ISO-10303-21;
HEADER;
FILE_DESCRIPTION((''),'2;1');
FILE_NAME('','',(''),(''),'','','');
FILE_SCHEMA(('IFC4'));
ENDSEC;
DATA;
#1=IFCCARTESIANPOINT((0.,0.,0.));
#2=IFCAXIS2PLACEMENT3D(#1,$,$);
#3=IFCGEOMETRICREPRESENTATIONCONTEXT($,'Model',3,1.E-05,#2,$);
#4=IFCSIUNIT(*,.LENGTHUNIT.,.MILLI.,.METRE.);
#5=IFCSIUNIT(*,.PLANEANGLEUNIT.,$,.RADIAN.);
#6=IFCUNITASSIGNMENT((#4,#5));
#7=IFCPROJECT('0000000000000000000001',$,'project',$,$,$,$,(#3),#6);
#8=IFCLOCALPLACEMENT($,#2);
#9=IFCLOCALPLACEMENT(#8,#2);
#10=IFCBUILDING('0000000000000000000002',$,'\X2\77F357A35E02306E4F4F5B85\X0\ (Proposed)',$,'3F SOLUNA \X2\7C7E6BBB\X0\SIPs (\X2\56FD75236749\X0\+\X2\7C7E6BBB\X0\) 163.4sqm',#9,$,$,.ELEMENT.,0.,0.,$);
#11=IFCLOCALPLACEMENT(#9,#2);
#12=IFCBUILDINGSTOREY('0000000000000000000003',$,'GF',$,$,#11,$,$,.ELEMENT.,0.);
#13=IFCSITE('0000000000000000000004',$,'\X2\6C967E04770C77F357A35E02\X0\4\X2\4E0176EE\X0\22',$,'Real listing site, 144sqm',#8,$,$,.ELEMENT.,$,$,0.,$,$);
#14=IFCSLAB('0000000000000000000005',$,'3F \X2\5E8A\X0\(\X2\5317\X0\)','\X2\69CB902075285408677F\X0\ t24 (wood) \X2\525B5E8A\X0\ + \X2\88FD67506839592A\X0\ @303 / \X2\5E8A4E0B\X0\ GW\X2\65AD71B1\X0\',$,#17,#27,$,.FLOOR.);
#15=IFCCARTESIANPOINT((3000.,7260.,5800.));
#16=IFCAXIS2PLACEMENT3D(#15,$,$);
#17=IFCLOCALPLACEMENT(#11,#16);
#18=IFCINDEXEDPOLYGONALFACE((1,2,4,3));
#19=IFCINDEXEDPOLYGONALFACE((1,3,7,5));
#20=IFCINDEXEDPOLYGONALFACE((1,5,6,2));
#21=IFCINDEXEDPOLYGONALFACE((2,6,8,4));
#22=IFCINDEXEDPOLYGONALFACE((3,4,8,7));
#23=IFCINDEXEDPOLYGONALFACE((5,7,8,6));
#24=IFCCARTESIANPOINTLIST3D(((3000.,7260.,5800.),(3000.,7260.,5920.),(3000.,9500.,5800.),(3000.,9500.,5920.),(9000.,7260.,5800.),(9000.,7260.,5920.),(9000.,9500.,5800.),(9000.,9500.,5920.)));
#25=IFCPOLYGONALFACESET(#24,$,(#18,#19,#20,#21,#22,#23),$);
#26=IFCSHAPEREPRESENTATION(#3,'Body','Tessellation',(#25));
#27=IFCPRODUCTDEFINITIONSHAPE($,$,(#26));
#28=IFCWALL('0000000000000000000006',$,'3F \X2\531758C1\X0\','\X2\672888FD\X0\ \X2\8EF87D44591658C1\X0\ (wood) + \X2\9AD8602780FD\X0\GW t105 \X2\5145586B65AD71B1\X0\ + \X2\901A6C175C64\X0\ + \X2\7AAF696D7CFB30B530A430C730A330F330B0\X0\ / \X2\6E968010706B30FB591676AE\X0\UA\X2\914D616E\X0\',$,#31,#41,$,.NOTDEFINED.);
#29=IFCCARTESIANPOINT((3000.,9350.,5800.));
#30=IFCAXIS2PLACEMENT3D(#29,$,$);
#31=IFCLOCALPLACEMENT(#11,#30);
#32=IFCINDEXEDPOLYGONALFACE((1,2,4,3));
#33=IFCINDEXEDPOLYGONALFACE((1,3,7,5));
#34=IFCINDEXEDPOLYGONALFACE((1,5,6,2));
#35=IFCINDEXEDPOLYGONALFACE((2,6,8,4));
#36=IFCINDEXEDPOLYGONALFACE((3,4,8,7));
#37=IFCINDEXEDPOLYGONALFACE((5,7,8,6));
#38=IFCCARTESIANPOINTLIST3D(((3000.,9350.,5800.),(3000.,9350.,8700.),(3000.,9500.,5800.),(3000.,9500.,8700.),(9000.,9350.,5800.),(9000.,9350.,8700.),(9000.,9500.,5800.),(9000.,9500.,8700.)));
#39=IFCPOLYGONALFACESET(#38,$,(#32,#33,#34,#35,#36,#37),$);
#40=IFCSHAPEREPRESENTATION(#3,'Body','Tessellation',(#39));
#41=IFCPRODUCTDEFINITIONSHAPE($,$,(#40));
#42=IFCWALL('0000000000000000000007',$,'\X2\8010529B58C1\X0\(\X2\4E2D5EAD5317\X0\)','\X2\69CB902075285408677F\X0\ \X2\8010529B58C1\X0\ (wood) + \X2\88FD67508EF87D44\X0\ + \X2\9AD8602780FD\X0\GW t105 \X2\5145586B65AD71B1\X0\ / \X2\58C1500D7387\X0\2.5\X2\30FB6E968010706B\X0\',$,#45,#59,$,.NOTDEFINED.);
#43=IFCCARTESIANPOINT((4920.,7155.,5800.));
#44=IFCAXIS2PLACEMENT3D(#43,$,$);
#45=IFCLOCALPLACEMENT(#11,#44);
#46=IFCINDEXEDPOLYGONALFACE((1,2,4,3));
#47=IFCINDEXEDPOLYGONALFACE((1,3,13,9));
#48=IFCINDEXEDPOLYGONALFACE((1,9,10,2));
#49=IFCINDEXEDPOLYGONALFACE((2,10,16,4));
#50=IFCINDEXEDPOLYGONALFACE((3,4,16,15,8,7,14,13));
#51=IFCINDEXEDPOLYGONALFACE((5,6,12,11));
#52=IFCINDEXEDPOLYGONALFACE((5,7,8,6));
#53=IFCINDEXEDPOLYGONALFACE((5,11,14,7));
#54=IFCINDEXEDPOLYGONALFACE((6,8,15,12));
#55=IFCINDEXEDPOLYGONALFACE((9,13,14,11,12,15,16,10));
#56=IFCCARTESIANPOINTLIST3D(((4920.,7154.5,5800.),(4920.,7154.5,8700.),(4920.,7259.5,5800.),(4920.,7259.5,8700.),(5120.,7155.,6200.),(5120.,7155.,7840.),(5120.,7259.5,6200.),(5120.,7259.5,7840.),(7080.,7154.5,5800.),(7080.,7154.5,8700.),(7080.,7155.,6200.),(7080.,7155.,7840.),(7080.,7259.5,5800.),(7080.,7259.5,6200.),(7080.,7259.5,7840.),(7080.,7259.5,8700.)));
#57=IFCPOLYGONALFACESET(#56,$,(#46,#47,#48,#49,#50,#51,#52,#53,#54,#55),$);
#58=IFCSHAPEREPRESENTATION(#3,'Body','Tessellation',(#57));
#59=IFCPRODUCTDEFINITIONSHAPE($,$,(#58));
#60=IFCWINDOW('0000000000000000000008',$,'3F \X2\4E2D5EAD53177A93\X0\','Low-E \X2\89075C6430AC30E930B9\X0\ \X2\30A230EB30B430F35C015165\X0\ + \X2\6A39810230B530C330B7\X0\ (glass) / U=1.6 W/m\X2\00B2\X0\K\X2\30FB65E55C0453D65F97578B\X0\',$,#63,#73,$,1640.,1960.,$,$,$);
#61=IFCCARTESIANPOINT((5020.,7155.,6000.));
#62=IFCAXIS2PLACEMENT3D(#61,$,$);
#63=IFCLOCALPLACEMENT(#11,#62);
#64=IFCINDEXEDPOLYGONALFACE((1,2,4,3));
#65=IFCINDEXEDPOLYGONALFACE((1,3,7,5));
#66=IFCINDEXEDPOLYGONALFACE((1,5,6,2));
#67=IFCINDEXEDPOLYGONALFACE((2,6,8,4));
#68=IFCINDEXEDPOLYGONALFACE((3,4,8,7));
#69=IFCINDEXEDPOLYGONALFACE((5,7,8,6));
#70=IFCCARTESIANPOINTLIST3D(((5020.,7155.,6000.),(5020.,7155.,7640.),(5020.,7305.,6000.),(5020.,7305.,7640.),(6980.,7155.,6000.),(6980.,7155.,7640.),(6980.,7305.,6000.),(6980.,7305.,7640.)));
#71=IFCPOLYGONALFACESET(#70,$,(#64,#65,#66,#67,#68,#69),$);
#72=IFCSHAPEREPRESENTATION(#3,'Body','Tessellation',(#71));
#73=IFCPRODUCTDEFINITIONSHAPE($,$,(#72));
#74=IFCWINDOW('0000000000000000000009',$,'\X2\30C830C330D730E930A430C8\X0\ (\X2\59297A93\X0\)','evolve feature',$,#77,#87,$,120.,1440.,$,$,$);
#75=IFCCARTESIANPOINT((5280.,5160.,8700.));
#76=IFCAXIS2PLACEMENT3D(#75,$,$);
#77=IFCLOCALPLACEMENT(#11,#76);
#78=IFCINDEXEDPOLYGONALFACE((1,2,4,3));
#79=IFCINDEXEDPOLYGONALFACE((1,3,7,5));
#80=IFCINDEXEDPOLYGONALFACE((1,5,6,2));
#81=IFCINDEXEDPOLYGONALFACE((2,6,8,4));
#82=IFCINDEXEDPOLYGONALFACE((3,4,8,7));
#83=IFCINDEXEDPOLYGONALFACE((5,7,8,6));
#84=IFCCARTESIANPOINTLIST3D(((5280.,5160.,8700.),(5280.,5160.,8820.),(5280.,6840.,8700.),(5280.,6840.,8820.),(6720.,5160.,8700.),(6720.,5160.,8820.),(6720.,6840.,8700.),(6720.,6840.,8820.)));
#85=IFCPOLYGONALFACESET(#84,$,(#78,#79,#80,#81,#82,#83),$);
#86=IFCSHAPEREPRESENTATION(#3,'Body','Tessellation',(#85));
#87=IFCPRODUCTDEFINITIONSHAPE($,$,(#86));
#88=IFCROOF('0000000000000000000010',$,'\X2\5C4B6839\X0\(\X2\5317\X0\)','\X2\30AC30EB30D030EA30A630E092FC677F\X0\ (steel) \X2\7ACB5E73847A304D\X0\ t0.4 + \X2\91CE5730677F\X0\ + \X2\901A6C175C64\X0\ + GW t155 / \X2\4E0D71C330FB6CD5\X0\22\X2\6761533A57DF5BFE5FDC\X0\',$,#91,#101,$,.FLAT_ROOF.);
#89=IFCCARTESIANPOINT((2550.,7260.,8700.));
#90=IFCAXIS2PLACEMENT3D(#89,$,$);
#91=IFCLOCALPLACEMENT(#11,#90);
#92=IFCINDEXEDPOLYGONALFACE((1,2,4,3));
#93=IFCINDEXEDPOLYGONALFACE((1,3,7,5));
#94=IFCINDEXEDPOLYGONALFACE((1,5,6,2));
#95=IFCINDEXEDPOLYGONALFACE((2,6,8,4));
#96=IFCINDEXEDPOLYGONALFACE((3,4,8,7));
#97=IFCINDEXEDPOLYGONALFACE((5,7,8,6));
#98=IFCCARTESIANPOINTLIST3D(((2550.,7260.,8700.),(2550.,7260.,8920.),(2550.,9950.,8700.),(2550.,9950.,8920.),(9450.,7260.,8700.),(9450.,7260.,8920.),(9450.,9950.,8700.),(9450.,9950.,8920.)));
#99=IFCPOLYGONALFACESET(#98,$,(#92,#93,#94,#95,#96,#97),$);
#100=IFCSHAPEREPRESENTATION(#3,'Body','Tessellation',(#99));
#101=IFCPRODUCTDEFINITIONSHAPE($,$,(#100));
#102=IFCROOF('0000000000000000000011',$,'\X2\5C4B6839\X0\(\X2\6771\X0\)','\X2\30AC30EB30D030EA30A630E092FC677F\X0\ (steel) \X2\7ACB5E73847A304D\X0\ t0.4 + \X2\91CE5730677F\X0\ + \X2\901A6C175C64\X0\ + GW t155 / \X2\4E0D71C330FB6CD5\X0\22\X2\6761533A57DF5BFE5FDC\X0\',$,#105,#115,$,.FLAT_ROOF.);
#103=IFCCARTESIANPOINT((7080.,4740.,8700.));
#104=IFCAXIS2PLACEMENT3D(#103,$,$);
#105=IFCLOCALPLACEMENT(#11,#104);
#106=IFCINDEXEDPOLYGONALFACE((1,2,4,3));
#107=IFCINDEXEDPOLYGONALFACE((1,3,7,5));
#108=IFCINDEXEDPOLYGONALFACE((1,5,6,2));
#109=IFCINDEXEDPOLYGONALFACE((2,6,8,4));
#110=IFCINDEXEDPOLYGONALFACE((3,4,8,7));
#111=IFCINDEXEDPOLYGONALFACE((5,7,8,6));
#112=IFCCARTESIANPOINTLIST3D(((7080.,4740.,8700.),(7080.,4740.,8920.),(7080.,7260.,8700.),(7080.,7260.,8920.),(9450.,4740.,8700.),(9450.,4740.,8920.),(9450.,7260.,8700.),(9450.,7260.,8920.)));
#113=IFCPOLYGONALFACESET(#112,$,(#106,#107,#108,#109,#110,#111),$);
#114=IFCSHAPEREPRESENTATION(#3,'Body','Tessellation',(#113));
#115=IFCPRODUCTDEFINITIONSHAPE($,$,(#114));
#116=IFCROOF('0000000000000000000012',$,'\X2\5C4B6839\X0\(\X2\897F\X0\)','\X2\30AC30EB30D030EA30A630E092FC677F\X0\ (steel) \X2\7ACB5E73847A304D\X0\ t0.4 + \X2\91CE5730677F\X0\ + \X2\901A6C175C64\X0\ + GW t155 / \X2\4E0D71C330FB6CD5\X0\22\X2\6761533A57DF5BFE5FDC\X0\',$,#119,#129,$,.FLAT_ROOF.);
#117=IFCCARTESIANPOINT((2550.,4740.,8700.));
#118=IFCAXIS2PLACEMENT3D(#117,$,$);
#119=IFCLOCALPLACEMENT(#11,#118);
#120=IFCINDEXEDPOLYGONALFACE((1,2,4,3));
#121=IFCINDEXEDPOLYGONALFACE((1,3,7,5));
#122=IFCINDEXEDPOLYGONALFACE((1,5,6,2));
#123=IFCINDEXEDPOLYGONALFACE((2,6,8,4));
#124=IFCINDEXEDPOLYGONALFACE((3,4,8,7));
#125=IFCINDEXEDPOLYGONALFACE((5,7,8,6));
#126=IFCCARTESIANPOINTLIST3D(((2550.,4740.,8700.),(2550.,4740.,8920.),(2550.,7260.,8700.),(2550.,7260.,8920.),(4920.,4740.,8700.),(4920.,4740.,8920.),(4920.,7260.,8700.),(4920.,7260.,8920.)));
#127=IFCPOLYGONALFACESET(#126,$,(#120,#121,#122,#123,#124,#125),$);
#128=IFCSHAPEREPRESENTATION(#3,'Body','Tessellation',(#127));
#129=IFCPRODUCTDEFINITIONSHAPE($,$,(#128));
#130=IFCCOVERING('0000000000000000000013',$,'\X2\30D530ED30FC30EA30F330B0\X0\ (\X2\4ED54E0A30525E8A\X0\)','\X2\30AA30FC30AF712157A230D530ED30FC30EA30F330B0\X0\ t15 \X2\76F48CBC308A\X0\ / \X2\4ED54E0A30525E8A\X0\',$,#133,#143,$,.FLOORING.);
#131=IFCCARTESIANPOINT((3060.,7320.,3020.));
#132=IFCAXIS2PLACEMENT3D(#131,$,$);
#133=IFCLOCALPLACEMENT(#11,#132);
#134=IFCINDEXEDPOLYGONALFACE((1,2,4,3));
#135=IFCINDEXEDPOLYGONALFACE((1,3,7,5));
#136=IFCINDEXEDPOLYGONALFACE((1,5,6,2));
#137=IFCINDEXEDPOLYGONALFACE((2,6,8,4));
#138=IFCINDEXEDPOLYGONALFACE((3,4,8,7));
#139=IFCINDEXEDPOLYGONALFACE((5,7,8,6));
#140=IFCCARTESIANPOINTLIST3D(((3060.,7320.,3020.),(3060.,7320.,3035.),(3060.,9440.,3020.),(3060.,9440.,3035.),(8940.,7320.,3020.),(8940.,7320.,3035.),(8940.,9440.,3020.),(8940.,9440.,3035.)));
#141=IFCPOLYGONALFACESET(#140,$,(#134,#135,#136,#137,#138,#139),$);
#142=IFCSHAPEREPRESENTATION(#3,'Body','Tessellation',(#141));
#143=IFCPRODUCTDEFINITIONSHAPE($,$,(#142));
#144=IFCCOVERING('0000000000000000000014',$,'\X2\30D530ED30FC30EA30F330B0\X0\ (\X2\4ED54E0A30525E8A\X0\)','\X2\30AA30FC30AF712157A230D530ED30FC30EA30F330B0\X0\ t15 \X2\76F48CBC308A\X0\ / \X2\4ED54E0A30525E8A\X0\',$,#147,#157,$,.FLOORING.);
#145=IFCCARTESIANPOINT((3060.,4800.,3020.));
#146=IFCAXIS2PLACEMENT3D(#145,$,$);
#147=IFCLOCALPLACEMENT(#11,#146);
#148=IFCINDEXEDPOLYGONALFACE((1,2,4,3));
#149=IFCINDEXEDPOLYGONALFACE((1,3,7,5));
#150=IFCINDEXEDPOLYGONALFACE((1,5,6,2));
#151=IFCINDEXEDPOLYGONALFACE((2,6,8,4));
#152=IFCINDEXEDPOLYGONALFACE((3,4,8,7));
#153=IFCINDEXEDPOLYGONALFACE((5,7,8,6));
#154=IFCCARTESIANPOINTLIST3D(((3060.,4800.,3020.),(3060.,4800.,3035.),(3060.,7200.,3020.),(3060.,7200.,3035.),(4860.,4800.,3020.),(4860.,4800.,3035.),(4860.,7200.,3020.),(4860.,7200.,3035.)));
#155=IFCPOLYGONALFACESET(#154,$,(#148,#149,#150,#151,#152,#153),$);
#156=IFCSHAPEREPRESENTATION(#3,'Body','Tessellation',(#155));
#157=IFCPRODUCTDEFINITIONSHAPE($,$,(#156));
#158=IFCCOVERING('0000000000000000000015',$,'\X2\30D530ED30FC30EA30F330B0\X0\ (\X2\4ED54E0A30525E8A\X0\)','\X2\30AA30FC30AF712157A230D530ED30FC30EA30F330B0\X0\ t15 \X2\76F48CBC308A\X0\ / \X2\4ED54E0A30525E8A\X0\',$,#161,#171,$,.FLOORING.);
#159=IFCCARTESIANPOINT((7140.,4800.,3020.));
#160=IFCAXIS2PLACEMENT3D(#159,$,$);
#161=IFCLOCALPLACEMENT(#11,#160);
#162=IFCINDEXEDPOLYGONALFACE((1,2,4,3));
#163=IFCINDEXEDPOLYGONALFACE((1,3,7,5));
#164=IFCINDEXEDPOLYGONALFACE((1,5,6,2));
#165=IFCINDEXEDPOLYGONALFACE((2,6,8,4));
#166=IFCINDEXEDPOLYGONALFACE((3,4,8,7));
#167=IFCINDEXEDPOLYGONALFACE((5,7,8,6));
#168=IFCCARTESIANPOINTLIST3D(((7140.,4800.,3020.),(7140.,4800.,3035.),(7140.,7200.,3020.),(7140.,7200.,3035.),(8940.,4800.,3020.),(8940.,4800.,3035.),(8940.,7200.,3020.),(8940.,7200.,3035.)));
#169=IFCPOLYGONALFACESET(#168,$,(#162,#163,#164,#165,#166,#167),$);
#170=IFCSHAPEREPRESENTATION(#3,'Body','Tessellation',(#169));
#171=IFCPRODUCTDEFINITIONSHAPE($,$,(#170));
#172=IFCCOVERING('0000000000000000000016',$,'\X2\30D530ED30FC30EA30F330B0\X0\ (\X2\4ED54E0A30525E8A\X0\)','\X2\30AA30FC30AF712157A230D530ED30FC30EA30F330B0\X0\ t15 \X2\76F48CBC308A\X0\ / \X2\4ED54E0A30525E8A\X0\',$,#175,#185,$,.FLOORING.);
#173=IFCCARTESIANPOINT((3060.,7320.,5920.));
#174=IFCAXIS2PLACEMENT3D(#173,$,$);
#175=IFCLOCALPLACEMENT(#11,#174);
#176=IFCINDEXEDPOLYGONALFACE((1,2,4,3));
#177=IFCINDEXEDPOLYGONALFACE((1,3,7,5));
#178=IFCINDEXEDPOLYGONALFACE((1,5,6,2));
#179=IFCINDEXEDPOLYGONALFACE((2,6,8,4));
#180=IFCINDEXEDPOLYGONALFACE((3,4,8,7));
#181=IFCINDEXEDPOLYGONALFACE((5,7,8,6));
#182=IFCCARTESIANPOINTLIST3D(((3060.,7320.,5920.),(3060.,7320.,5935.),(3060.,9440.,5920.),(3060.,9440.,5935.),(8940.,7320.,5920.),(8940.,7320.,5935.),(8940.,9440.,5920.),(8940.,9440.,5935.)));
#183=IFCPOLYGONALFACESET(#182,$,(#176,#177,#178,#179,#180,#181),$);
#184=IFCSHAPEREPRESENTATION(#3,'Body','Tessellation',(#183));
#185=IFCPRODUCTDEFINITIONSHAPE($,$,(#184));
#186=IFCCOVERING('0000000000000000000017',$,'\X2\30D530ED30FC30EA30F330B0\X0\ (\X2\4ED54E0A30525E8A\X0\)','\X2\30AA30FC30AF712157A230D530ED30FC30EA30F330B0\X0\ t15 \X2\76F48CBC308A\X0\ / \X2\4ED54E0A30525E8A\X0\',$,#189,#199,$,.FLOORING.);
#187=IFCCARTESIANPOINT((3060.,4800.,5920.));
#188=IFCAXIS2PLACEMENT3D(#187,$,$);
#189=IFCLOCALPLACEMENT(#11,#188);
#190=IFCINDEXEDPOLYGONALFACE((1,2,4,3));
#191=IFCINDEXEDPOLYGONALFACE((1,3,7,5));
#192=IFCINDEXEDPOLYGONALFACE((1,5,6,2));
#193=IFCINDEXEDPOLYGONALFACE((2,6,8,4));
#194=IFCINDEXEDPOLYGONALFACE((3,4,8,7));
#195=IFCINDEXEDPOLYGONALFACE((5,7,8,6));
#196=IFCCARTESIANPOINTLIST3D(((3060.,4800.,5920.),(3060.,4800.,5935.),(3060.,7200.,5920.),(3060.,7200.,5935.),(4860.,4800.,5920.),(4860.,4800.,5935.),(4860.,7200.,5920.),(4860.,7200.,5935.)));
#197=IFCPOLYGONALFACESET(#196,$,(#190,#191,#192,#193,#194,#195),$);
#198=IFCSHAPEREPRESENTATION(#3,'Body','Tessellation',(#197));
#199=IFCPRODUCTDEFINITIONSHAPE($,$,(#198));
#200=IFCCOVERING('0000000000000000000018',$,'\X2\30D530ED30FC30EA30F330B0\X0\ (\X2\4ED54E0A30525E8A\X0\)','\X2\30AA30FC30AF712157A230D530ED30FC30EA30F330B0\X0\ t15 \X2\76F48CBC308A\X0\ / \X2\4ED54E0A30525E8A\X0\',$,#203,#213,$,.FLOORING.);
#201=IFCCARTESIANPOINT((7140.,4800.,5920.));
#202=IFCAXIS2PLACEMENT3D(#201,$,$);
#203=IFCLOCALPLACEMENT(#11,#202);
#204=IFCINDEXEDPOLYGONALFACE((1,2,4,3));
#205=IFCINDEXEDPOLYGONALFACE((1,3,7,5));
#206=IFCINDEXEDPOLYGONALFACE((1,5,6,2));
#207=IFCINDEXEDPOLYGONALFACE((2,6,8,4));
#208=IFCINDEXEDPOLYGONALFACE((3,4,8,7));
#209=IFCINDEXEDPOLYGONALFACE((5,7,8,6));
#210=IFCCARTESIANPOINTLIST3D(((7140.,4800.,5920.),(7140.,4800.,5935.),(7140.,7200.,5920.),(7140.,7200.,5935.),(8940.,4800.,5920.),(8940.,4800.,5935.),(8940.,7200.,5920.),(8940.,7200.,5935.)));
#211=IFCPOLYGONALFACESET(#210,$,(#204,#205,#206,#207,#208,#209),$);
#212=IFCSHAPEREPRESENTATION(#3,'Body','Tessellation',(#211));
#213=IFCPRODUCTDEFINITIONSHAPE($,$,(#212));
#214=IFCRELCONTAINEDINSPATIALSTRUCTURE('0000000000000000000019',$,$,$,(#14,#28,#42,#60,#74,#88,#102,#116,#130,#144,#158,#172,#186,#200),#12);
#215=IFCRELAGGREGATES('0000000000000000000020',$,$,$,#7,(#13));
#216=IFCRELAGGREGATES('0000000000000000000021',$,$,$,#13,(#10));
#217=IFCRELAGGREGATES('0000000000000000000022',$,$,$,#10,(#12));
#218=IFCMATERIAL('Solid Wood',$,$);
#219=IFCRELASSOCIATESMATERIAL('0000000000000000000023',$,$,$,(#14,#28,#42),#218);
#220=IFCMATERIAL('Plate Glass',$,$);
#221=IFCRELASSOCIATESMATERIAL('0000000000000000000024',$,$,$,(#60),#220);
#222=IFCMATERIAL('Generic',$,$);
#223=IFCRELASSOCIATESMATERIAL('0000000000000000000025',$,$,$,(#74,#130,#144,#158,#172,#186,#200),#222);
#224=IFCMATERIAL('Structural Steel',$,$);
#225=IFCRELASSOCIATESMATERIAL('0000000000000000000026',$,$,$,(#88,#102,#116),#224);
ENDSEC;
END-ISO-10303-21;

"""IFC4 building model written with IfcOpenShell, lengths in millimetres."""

from ifc_helpers import new_model, si_unit, frame, frame_2d, origin, place, context, project, spatial, rectangle, extrude, material, element, fill, save


model = new_model("IFC4")

# Units and contexts
model_context = context("Model", 3, precision=1e-05, world=origin())
ifc_project = project(units=[si_unit("LENGTHUNIT", "METRE", prefix="MILLI"), si_unit("PLANEANGLEUNIT", "RADIAN")], contexts=[model_context])

# Site, building, storey
site_placement = place(None, origin())
site = spatial("IfcSite", under=ifc_project, at=site_placement, Name="沖縄県石垣市4丁目22", ObjectType="Real listing site, 144sqm", CompositionType="ELEMENT", RefElevation=0.0)
building_placement = place(site_placement, origin())
building = spatial("IfcBuilding", under=site, at=building_placement, Name="石垣市の住宅 (Proposed)", ObjectType="3F SOLUNA 籾殻SIPs (国産杉+籾殻) 163.4sqm", CompositionType="ELEMENT", ElevationOfRefHeight=0.0, ElevationOfTerrain=0.0)
storey_placement = place(building_placement, origin())
storey = spatial("IfcBuildingStorey", under=building, at=storey_placement, Name="GF", CompositionType="ELEMENT", Elevation=0.0)

# Slab
ifc_material_1 = material(Name="Solid Wood")
slab_placement = place(storey_placement, frame((3000.0, 7260.0, 5800.0)))
element("IfcSlab", 1, at=slab_placement, inside=storey, material=ifc_material_1, Name="3F 床(北)", Description="構造用合板 t24 (wood) 剛床 + 製材根太 @303 / 床下 GW断熱", PredefinedType="FLOOR", context=model_context, shape_type="SweptSolid", body=[
    extrude(rectangle(XDim=6000.0, YDim=2240.0, at=frame_2d((3000.0, 1120.0))), frame((3000.0, 7260.0, 5800.0)), (0.0, 0.0, 1.0), 120.0),
])

# Wall
wall_1_placement = place(storey_placement, frame((3000.0, 9350.0, 5800.0)))
element("IfcWall", 2, at=wall_1_placement, inside=storey, material=ifc_material_1, Name="3F 北壁", Description="木製 軸組外壁 (wood) + 高性能GW t105 充填断熱 + 通気層 + 窯業系サイディング / 準耐火・外皮UA配慮", PredefinedType="NOTDEFINED", context=model_context, shape_type="SweptSolid", body=[
    extrude(rectangle(XDim=6000.0, YDim=150.0, at=frame_2d((3000.0, 75.0))), frame((3000.0, 9350.0, 5800.0)), (0.0, 0.0, 1.0), 2900.0),
])

# Wall, opening, window
wall_2_placement = place(storey_placement, frame((4920.0, 7155.0, 5800.0)))
wall_2 = element("IfcWall", 3, at=wall_2_placement, inside=storey, material=ifc_material_1, Name="耐力壁(中庭北)", Description="構造用合板 耐力壁 (wood) + 製材軸組 + 高性能GW t105 充填断熱 / 壁倍率2.5・準耐火", PredefinedType="NOTDEFINED", context=model_context, shape_type="SweptSolid", body=[
    extrude(rectangle(XDim=2160.0, YDim=105.0, at=frame_2d((1080.0, 52.0))), frame((4920.0, 7155.0, 5800.0)), (0.0, 0.0, 1.0), 2900.0),
])
opening_placement = place(storey_placement, frame((5020.0, 7155.0, 6000.0)))
opening = element("IfcOpeningElement", 4, at=opening_placement, cuts=wall_2, PredefinedType="NOTDEFINED", context=model_context, shape_type="SweptSolid", body=[
    extrude(rectangle(XDim=1960.0, YDim=150.0, at=frame_2d((980.0, 75.0))), frame((5020.0, 7155.0, 6000.0)), (0.0, 0.0, 1.0), 1640.0),
])
ifc_material_2 = material(Name="Plate Glass")
window_1_placement = place(storey_placement, frame((5020.0, 7155.0, 6000.0)))
window_1 = element("IfcWindow", 5, at=window_1_placement, inside=storey, material=ifc_material_2, Name="3F 中庭北窓", Description="Low-E 複層ガラス アルゴン封入 + 樹脂サッシ (glass) / U=1.6 W/m²K・日射取得型", OverallHeight=1640.0, OverallWidth=1960.0, context=model_context, shape_type="SweptSolid", body=[
    extrude(rectangle(XDim=1960.0, YDim=150.0, at=frame_2d((980.0, 75.0))), frame((5020.0, 7155.0, 6000.0)), (0.0, 0.0, 1.0), 1640.0),
])
fill(opening, window_1)

# Window
ifc_material_3 = material(Name="Generic")
window_2_placement = place(storey_placement, frame((5280.0, 5160.0, 8700.0)))
element("IfcWindow", 6, at=window_2_placement, inside=storey, material=ifc_material_3, Name="トップライト (天窓)", Description="evolve feature", OverallHeight=120.0, OverallWidth=1440.0, context=model_context, shape_type="SweptSolid", body=[
    extrude(rectangle(XDim=1440.0, YDim=1680.0, at=frame_2d((720.0, 840.0))), frame((5280.0, 5160.0, 8700.0)), (0.0, 0.0, 1.0), 120.0),
])

# Roofs
ifc_material_4 = material(Name="Structural Steel")
roof_1_placement = place(storey_placement, frame((2550.0, 7260.0, 8700.0)))
element("IfcRoof", 7, at=roof_1_placement, inside=storey, material=ifc_material_4, Name="屋根(北)", Description="ガルバリウム鋼板 (steel) 立平葺き t0.4 + 野地板 + 通気層 + GW t155 / 不燃・法22条区域対応", PredefinedType="FLAT_ROOF", context=model_context, shape_type="SweptSolid", body=[
    extrude(rectangle(XDim=6900.0, YDim=2690.0, at=frame_2d((3450.0, 1345.0))), frame((2550.0, 7260.0, 8700.0)), (0.0, 0.0, 1.0), 220.0),
])
roof_2_placement = place(storey_placement, frame((7080.0, 4740.0, 8700.0)))
element("IfcRoof", 8, at=roof_2_placement, inside=storey, material=ifc_material_4, Name="屋根(東)", Description="ガルバリウム鋼板 (steel) 立平葺き t0.4 + 野地板 + 通気層 + GW t155 / 不燃・法22条区域対応", PredefinedType="FLAT_ROOF", context=model_context, shape_type="SweptSolid", body=[
    extrude(rectangle(XDim=2370.0, YDim=2520.0, at=frame_2d((1185.0, 1260.0))), frame((7080.0, 4740.0, 8700.0)), (0.0, 0.0, 1.0), 220.0),
])
roof_3_placement = place(storey_placement, frame((2550.0, 4740.0, 8700.0)))
element("IfcRoof", 9, at=roof_3_placement, inside=storey, material=ifc_material_4, Name="屋根(西)", Description="ガルバリウム鋼板 (steel) 立平葺き t0.4 + 野地板 + 通気層 + GW t155 / 不燃・法22条区域対応", PredefinedType="FLAT_ROOF", context=model_context, shape_type="SweptSolid", body=[
    extrude(rectangle(XDim=2370.0, YDim=2520.0, at=frame_2d((1185.0, 1260.0))), frame((2550.0, 4740.0, 8700.0)), (0.0, 0.0, 1.0), 220.0),
])

# Coverings
covering_1_placement = place(storey_placement, frame((3060.0, 7320.0, 3020.0)))
element("IfcCovering", 10, at=covering_1_placement, inside=storey, material=ifc_material_3, Name="フローリング (仕上げ床)", Description="オーク無垢フローリング t15 直貼り / 仕上げ床", PredefinedType="FLOORING", context=model_context, shape_type="SweptSolid", body=[
    extrude(rectangle(XDim=5880.0, YDim=2120.0, at=frame_2d((2940.0, 1060.0))), frame((3060.0, 7320.0, 3020.0)), (0.0, 0.0, 1.0), 15.0),
])
covering_2_placement = place(storey_placement, frame((3060.0, 4800.0, 3020.0)))
element("IfcCovering", 11, at=covering_2_placement, inside=storey, material=ifc_material_3, Name="フローリング (仕上げ床)", Description="オーク無垢フローリング t15 直貼り / 仕上げ床", PredefinedType="FLOORING", context=model_context, shape_type="SweptSolid", body=[
    extrude(rectangle(XDim=1800.0, YDim=2400.0, at=frame_2d((900.0, 1200.0))), frame((3060.0, 4800.0, 3020.0)), (0.0, 0.0, 1.0), 15.0),
])
covering_3_placement = place(storey_placement, frame((7140.0, 4800.0, 3020.0)))
element("IfcCovering", 12, at=covering_3_placement, inside=storey, material=ifc_material_3, Name="フローリング (仕上げ床)", Description="オーク無垢フローリング t15 直貼り / 仕上げ床", PredefinedType="FLOORING", context=model_context, shape_type="SweptSolid", body=[
    extrude(rectangle(XDim=1800.0, YDim=2400.0, at=frame_2d((900.0, 1200.0))), frame((7140.0, 4800.0, 3020.0)), (0.0, 0.0, 1.0), 15.0),
])
covering_4_placement = place(storey_placement, frame((3060.0, 7320.0, 5920.0)))
element("IfcCovering", 13, at=covering_4_placement, inside=storey, material=ifc_material_3, Name="フローリング (仕上げ床)", Description="オーク無垢フローリング t15 直貼り / 仕上げ床", PredefinedType="FLOORING", context=model_context, shape_type="SweptSolid", body=[
    extrude(rectangle(XDim=5880.0, YDim=2120.0, at=frame_2d((2940.0, 1060.0))), frame((3060.0, 7320.0, 5920.0)), (0.0, 0.0, 1.0), 15.0),
])
covering_5_placement = place(storey_placement, frame((3060.0, 4800.0, 5920.0)))
element("IfcCovering", 14, at=covering_5_placement, inside=storey, material=ifc_material_3, Name="フローリング (仕上げ床)", Description="オーク無垢フローリング t15 直貼り / 仕上げ床", PredefinedType="FLOORING", context=model_context, shape_type="SweptSolid", body=[
    extrude(rectangle(XDim=1800.0, YDim=2400.0, at=frame_2d((900.0, 1200.0))), frame((3060.0, 4800.0, 5920.0)), (0.0, 0.0, 1.0), 15.0),
])
covering_6_placement = place(storey_placement, frame((7140.0, 4800.0, 5920.0)))
element("IfcCovering", 15, at=covering_6_placement, inside=storey, material=ifc_material_3, Name="フローリング (仕上げ床)", Description="オーク無垢フローリング t15 直貼り / 仕上げ床", PredefinedType="FLOORING", context=model_context, shape_type="SweptSolid", body=[
    extrude(rectangle(XDim=1800.0, YDim=2400.0, at=frame_2d((900.0, 1200.0))), frame((7140.0, 4800.0, 5920.0)), (0.0, 0.0, 1.0), 15.0),
])

save(model, "model.ifc")
